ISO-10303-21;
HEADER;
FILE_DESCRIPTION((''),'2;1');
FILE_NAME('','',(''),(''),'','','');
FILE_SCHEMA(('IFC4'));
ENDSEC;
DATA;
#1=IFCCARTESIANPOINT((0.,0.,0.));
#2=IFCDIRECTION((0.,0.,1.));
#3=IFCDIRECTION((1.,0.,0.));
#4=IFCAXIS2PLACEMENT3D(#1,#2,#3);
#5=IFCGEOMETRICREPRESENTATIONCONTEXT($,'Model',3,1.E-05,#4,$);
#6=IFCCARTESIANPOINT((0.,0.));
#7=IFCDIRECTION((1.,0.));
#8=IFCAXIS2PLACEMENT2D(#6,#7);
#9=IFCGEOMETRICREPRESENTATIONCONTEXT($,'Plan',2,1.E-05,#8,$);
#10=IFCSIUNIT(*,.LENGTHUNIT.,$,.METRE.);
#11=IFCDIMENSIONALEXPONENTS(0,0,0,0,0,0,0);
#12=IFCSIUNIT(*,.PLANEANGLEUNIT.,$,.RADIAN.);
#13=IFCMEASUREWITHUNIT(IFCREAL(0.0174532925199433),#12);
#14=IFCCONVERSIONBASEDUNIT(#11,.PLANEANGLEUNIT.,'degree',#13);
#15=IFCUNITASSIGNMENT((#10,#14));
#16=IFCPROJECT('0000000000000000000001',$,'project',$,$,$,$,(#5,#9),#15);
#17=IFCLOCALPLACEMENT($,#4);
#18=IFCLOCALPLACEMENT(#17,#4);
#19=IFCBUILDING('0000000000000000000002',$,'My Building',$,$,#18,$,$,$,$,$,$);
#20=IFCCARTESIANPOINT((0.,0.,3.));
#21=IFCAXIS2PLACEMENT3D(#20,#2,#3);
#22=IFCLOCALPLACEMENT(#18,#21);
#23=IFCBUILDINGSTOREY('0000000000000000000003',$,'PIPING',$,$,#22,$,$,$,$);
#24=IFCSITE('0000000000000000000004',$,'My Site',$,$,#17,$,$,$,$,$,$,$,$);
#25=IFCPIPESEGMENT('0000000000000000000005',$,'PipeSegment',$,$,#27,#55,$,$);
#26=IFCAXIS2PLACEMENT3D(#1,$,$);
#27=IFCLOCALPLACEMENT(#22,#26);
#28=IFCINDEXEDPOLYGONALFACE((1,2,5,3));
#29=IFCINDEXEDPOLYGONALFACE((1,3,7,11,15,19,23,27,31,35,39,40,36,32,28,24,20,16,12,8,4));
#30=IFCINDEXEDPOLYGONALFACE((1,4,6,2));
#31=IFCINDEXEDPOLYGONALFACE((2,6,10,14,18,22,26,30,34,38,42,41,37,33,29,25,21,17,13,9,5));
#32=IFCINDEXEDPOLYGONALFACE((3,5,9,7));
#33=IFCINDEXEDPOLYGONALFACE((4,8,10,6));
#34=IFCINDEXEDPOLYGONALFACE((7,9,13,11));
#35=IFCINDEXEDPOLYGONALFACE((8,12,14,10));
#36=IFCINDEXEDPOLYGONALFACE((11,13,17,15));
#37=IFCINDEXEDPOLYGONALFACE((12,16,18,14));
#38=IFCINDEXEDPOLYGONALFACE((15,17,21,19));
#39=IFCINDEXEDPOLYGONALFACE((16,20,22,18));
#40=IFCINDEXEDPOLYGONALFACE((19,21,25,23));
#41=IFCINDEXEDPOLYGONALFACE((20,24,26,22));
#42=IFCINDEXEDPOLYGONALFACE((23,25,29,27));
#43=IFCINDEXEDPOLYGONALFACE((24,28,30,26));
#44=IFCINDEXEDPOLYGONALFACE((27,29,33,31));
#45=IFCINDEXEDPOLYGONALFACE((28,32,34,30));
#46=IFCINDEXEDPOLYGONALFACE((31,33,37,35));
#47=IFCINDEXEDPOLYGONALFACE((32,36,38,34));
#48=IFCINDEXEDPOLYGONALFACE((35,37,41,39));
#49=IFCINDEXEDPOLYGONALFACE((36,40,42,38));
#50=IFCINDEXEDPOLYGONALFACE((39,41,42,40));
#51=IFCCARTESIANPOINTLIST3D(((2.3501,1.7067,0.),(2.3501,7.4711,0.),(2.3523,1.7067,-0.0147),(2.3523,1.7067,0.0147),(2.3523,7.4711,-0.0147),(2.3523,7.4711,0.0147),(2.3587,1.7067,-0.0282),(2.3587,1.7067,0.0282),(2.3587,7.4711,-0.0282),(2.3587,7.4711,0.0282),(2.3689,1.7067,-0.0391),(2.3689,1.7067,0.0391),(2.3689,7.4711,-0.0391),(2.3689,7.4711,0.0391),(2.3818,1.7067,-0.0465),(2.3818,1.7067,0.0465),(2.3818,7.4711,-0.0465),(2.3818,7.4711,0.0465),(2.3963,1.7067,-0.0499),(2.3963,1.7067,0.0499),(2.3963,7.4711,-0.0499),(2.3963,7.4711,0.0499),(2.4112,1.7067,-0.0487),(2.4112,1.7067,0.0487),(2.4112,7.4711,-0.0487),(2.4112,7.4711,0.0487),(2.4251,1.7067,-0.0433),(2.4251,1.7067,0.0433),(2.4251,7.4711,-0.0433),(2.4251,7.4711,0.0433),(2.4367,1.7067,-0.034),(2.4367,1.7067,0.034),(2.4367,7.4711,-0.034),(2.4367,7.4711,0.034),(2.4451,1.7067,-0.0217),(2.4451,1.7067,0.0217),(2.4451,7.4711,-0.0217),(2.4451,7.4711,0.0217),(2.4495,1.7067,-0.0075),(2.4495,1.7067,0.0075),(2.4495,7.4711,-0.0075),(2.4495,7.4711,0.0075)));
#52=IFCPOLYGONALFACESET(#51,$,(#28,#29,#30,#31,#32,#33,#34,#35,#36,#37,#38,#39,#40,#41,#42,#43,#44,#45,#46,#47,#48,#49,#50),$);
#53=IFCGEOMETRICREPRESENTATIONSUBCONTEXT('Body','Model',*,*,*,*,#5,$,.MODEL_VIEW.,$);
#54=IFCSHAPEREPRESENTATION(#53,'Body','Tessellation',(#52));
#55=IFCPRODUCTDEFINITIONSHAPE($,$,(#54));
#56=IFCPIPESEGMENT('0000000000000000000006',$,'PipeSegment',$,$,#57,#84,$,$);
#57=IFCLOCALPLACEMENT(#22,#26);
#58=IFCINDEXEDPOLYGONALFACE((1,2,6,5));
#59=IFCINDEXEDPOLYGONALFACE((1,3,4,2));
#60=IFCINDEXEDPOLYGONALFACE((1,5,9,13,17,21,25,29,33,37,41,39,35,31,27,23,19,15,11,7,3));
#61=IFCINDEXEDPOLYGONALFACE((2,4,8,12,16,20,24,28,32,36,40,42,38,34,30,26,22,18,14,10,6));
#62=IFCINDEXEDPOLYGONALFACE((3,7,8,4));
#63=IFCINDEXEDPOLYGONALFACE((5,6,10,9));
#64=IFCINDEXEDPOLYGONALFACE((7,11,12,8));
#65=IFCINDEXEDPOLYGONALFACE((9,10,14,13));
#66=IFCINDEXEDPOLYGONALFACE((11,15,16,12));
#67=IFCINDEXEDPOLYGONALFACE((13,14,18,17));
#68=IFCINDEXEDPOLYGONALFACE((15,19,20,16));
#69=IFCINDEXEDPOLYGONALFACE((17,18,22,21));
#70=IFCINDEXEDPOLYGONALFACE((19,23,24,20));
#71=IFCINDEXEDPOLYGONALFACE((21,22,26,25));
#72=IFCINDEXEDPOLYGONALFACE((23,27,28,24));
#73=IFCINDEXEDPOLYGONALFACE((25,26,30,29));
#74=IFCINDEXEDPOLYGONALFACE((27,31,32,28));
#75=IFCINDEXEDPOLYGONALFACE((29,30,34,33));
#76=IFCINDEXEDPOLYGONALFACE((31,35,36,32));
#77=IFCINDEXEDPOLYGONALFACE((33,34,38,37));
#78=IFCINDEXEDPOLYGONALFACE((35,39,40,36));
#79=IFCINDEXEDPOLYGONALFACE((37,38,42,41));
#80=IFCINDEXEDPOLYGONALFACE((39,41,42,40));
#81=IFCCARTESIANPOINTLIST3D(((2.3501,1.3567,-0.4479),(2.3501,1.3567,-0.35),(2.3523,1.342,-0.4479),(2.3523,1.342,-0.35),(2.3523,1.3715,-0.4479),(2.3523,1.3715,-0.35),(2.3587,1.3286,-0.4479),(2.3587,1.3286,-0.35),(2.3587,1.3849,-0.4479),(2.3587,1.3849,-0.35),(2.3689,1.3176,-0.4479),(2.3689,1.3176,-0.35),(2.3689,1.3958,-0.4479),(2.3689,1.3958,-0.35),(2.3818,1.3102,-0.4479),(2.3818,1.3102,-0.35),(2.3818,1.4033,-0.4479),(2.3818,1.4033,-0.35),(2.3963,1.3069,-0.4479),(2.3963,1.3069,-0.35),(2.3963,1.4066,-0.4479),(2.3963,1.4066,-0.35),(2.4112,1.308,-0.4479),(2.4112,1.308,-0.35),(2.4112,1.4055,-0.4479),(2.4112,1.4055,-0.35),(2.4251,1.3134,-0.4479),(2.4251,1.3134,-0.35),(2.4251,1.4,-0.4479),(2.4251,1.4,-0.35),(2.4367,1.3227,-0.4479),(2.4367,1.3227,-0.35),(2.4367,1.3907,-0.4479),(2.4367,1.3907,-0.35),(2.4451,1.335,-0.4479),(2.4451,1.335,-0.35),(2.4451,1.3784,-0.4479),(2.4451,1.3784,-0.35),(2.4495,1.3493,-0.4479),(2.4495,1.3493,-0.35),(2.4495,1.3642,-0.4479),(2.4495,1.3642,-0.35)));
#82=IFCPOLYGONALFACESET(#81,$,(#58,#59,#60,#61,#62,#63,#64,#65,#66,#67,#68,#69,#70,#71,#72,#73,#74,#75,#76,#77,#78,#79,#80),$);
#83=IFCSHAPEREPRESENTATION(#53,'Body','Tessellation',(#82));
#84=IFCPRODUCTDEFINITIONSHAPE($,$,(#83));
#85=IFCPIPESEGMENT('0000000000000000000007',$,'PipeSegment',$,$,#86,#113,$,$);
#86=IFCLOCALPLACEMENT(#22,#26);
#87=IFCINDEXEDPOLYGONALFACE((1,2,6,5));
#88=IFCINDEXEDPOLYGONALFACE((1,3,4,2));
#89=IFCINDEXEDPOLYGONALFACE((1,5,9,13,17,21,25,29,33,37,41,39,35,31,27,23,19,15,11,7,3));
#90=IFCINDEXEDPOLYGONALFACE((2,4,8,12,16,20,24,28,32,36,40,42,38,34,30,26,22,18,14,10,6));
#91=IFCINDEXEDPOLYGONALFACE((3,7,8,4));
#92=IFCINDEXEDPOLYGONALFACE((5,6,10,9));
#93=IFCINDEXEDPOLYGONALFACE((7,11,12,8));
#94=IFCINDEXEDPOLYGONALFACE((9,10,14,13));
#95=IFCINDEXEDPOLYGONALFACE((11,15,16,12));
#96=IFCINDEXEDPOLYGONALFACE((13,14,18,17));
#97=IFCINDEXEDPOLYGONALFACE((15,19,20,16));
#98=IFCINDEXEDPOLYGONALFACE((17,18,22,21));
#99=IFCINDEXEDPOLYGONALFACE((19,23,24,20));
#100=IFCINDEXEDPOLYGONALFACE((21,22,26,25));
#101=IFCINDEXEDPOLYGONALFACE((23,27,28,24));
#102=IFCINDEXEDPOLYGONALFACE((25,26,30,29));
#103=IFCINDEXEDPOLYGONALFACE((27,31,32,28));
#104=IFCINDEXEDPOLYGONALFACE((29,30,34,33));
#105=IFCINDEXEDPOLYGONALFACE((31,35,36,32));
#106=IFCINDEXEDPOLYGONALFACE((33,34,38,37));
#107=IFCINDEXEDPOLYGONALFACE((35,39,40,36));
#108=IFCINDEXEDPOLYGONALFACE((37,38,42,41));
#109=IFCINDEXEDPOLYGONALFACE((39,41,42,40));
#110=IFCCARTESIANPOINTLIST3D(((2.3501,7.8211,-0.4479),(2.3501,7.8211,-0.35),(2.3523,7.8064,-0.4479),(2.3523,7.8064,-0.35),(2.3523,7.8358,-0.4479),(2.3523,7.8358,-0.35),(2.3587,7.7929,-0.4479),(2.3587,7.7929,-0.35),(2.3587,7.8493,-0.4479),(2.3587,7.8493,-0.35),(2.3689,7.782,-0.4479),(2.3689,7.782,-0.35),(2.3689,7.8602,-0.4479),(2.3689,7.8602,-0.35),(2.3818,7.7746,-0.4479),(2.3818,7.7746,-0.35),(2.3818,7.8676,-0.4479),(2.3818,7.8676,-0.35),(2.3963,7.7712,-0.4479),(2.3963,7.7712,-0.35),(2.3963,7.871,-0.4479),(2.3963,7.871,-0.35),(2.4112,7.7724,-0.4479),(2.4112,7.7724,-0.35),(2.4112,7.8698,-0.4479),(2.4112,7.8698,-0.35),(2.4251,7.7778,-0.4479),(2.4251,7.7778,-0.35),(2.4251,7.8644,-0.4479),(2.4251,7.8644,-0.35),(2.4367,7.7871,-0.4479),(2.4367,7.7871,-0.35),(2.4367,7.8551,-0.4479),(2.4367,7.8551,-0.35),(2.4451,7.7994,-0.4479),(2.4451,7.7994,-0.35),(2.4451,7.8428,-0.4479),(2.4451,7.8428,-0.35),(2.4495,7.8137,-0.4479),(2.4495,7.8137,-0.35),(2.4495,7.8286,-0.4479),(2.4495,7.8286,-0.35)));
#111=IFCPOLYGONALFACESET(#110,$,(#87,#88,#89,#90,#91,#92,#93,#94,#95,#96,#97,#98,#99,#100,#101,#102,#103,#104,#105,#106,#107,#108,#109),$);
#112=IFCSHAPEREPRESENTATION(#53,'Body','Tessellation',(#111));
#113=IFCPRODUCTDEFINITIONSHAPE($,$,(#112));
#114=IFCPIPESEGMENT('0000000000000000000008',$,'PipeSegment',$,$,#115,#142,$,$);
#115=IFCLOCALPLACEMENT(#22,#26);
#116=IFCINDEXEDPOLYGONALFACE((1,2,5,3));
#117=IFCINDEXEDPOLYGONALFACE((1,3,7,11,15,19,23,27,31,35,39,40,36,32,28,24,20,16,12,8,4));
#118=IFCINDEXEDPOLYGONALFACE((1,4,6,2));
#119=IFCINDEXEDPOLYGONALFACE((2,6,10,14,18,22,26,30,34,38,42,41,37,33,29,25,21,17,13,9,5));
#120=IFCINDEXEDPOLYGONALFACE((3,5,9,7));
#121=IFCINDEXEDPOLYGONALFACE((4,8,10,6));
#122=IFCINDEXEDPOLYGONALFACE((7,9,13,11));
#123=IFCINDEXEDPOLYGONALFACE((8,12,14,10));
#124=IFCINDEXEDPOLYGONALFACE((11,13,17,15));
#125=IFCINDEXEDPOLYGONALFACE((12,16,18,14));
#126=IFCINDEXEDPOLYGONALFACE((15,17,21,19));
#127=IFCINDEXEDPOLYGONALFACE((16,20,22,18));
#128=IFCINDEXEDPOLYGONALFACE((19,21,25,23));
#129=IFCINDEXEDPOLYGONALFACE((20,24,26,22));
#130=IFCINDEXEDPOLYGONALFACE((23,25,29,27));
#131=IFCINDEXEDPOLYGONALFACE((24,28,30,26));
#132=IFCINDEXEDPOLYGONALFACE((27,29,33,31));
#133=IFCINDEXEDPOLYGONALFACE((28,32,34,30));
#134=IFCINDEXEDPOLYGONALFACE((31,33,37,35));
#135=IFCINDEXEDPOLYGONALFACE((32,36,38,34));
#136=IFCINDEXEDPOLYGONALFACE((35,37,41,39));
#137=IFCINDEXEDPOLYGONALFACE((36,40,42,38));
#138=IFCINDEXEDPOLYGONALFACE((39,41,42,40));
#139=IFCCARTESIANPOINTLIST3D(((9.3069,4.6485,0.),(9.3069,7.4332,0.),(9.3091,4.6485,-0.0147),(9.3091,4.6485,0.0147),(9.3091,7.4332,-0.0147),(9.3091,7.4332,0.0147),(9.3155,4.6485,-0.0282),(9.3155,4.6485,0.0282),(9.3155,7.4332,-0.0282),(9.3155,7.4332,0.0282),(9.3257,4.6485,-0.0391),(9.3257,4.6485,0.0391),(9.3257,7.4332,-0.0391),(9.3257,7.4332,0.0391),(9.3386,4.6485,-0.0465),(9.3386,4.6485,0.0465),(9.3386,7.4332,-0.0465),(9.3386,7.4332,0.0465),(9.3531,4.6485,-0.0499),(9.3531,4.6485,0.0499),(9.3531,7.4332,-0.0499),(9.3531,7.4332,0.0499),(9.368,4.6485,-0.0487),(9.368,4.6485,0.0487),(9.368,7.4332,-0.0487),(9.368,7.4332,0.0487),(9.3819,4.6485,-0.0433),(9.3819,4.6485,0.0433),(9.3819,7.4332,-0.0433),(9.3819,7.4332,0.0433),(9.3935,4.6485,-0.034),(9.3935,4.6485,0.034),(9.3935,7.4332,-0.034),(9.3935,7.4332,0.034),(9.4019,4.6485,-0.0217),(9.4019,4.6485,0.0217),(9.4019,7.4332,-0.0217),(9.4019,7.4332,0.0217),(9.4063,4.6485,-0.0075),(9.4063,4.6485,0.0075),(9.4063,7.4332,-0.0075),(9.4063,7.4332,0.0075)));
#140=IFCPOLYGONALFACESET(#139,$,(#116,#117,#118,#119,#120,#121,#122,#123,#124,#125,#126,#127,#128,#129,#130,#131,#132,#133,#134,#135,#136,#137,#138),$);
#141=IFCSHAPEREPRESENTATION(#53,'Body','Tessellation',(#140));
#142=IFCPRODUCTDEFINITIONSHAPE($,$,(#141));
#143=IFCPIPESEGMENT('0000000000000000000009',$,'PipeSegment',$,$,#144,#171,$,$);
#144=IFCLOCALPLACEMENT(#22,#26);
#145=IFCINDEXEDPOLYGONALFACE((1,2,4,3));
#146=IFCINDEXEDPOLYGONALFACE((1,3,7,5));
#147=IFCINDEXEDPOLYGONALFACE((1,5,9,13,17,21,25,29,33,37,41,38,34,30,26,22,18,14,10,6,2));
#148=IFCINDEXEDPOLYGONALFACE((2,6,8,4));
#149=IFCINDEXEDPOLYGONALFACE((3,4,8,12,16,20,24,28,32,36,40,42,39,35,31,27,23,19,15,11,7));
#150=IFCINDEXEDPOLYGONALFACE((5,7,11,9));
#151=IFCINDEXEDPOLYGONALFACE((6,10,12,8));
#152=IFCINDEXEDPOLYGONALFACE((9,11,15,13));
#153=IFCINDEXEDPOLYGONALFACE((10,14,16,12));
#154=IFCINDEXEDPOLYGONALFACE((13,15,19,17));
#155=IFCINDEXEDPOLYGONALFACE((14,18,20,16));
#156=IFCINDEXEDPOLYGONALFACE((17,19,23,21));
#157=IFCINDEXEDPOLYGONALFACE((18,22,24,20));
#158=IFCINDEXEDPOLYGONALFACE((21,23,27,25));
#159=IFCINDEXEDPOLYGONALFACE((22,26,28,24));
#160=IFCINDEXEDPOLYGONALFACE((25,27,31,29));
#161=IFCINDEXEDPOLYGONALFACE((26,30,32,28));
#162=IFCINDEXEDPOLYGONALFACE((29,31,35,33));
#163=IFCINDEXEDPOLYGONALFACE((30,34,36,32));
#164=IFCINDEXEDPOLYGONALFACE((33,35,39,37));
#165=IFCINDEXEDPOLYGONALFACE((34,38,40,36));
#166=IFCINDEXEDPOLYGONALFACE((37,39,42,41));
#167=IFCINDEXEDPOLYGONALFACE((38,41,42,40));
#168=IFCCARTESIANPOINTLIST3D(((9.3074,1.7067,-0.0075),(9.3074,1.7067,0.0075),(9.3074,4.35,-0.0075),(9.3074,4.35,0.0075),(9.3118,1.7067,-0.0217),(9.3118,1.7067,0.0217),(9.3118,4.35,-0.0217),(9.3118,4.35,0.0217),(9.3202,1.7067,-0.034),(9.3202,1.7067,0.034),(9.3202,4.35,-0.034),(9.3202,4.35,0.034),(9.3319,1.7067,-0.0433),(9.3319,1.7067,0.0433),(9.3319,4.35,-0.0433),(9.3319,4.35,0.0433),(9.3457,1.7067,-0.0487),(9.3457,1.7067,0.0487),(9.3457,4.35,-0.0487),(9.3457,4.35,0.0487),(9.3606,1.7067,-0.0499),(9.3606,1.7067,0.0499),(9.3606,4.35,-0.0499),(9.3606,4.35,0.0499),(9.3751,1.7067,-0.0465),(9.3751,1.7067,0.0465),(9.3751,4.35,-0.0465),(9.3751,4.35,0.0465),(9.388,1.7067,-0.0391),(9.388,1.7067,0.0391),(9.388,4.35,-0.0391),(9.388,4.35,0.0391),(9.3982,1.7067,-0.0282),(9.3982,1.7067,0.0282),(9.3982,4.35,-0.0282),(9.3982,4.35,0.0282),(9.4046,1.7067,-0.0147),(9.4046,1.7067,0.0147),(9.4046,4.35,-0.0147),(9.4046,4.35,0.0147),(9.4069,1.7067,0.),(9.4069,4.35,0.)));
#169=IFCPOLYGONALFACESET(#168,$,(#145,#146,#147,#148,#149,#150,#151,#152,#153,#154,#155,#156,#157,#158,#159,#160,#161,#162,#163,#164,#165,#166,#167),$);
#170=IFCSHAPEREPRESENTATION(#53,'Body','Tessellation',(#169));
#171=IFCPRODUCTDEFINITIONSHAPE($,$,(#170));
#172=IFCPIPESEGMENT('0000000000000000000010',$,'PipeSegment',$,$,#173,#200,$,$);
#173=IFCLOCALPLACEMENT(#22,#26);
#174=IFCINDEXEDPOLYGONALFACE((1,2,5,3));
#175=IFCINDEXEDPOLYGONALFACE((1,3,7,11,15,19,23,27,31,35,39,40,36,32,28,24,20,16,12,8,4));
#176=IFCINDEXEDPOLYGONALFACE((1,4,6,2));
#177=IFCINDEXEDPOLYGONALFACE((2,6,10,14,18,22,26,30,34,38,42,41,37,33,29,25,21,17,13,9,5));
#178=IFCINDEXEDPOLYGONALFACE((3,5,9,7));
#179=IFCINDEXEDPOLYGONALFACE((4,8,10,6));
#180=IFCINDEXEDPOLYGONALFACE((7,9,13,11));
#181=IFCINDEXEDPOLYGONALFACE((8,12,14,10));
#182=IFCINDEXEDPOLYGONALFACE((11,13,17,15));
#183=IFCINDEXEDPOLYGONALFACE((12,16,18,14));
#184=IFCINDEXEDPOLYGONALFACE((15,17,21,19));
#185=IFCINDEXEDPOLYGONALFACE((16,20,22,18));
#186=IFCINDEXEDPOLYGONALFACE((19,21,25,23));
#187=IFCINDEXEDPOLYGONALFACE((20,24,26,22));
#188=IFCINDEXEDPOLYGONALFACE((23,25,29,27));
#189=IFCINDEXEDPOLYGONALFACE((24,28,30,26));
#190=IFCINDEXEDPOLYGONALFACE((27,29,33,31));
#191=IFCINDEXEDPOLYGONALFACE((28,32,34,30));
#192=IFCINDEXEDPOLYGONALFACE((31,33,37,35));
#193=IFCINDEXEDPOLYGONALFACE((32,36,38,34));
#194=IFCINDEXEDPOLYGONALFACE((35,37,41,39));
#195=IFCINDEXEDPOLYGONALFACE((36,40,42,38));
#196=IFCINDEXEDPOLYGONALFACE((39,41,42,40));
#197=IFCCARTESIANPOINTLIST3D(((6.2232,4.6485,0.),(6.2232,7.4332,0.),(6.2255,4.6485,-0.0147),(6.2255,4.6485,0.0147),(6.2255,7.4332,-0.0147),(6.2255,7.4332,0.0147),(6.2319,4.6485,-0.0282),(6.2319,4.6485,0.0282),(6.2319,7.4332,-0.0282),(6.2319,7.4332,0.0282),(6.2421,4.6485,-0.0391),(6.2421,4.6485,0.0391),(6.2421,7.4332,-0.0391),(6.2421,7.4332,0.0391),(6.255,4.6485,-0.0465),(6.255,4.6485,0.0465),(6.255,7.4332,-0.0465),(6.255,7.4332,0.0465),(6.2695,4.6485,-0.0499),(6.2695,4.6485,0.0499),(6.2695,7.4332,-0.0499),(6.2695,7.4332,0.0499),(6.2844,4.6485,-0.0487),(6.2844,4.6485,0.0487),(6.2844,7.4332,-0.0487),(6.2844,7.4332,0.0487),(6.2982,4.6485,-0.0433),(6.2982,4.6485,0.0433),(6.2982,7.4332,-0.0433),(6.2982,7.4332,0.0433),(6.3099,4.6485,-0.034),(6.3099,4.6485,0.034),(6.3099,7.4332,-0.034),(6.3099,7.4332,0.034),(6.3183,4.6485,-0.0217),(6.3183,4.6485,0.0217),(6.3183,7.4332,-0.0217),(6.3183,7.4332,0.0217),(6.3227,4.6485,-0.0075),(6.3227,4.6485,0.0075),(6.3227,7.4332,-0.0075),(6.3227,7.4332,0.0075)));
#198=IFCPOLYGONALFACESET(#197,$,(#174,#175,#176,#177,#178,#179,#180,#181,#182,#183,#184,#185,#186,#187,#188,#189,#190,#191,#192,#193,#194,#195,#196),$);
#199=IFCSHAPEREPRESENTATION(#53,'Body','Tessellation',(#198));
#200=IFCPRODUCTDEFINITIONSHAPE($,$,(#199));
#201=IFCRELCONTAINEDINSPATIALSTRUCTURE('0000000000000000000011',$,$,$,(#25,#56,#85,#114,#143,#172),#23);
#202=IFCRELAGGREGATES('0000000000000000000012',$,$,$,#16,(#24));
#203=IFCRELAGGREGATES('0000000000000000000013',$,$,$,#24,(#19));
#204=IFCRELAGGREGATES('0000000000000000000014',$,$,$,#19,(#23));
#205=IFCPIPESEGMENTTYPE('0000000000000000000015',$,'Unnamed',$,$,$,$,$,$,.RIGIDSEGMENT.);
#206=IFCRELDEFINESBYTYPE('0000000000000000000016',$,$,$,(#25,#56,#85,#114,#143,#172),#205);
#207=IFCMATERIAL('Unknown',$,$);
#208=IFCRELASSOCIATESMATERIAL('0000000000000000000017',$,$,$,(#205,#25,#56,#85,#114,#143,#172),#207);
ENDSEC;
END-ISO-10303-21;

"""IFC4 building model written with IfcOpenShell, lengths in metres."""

from ifc_helpers import new_model, entity, si_unit, converted_unit, frame, origin_with_axes, origin_2d_with_axis, place, context, subcontext, project, spatial, circle, extrude, material, material_profile, profile_set, profile_usage, type_object, element, save


model = new_model("IFC4")

# Units and contexts
model_context = context("Model", 3, precision=1e-05, world=origin_with_axes())
plan_context = context("Plan", 2, precision=1e-05, world=origin_2d_with_axis())
body_context = subcontext(model_context, "Body", "Model", "MODEL_VIEW")
ifc_project = project(units=[si_unit("LENGTHUNIT", "METRE"), converted_unit("PLANEANGLEUNIT", "degree", entity("IfcReal", 0.0174532925199433), si_unit("PLANEANGLEUNIT", "RADIAN"), dimensions=[0, 0, 0, 0, 0, 0, 0])], contexts=[model_context, plan_context])

# Site, building, storey
site_placement = place(None, origin_with_axes())
site = spatial("IfcSite", under=ifc_project, at=site_placement, Name="My Site")
building_placement = place(site_placement, origin_with_axes())
building = spatial("IfcBuilding", under=site, at=building_placement, Name="My Building")
storey_placement = place(building_placement, frame((0.0, 0.0, 3.0), z_axis=(0.0, 0.0, 1.0), x_axis=(1.0, 0.0, 0.0)))
storey = spatial("IfcBuildingStorey", under=building, at=storey_placement, Name="PIPING")

# Pipe segments
ifc_material = material(Name="Unknown")
ifc_material_profile_1 = material_profile(ifc_material, circle(Radius=0.05))
ifc_profile_set_1 = profile_set([ifc_material_profile_1])
ifc_profile_usage_1 = profile_usage(ifc_profile_set_1, cardinal=5)
pipe_segment_type = type_object("IfcPipeSegmentType", Name="Unnamed", PredefinedType="RIGIDSEGMENT", material=ifc_profile_set_1)
pipe_segment_1_placement = place(storey_placement, frame((2.4001, 1.7067, 0.0), z_axis=(0.0, 1.0, 0.0), x_axis=(-1.0, 0.0, 0.0)))
element("IfcPipeSegment", 1, at=pipe_segment_1_placement, inside=storey, type_object=pipe_segment_type, material=ifc_profile_usage_1, Name="PipeSegment", context=body_context, shape_type="SweptSolid", body=[
    extrude(circle(Radius=0.05), origin_with_axes(), (0.0, 0.0, 1.0), 5.7644),
])
ifc_profile_usage_2 = profile_usage(ifc_profile_set_1, cardinal=5)
pipe_segment_2_placement = place(storey_placement, frame((2.4001, 1.3567, -0.35), z_axis=(0.0, 0.0, -1.0), x_axis=(-1.0, 0.0, 0.0)))
element("IfcPipeSegment", 2, at=pipe_segment_2_placement, inside=storey, type_object=pipe_segment_type, material=ifc_profile_usage_2, Name="PipeSegment", context=body_context, shape_type="SweptSolid", body=[
    extrude(circle(Radius=0.05), origin_with_axes(), (0.0, 0.0, 1.0), 0.0979),
])
ifc_profile_usage_3 = profile_usage(ifc_profile_set_1, cardinal=5)
pipe_segment_3_placement = place(storey_placement, frame((2.4001, 7.8211, -0.35), z_axis=(0.0, 0.0, -1.0), x_axis=(-1.0, 0.0, 0.0)))
element("IfcPipeSegment", 3, at=pipe_segment_3_placement, inside=storey, type_object=pipe_segment_type, material=ifc_profile_usage_3, Name="PipeSegment", context=body_context, shape_type="SweptSolid", body=[
    extrude(circle(Radius=0.05), origin_with_axes(), (0.0, 0.0, 1.0), 0.0979),
])
ifc_profile_usage_4 = profile_usage(ifc_profile_set_1, cardinal=5)
pipe_segment_4_placement = place(storey_placement, frame((9.3569, 4.6485, 0.0), z_axis=(0.0, 1.0, 0.0), x_axis=(-1.0, 0.0, 0.0)))
element("IfcPipeSegment", 4, at=pipe_segment_4_placement, inside=storey, type_object=pipe_segment_type, material=ifc_profile_usage_4, Name="PipeSegment", context=body_context, shape_type="SweptSolid", body=[
    extrude(circle(Radius=0.05), origin_with_axes(), (0.0, 0.0, 1.0), 2.7847),
])
ifc_profile_usage_5 = profile_usage(ifc_profile_set_1, cardinal=5)
pipe_segment_5_placement = place(storey_placement, frame((9.3569, 4.35, 0.0), z_axis=(0.0, -1.0, 0.0), x_axis=(1.0, 0.0, 0.0)))
element("IfcPipeSegment", 5, at=pipe_segment_5_placement, inside=storey, type_object=pipe_segment_type, material=ifc_profile_usage_5, Name="PipeSegment", context=body_context, shape_type="SweptSolid", body=[
    extrude(circle(Radius=0.05), origin_with_axes(), (0.0, 0.0, 1.0), 2.6433),
])
ifc_profile_usage_6 = profile_usage(ifc_profile_set_1, cardinal=5)
pipe_segment_6_placement = place(storey_placement, frame((6.2732, 4.6485, 0.0), z_axis=(0.0, 1.0, 0.0), x_axis=(-1.0, 0.0, 0.0)))
element("IfcPipeSegment", 6, at=pipe_segment_6_placement, inside=storey, type_object=pipe_segment_type, material=ifc_profile_usage_6, Name="PipeSegment", context=body_context, shape_type="SweptSolid", body=[
    extrude(circle(Radius=0.05), origin_with_axes(), (0.0, 0.0, 1.0), 2.7847),
])

save(model, "model.ifc")
